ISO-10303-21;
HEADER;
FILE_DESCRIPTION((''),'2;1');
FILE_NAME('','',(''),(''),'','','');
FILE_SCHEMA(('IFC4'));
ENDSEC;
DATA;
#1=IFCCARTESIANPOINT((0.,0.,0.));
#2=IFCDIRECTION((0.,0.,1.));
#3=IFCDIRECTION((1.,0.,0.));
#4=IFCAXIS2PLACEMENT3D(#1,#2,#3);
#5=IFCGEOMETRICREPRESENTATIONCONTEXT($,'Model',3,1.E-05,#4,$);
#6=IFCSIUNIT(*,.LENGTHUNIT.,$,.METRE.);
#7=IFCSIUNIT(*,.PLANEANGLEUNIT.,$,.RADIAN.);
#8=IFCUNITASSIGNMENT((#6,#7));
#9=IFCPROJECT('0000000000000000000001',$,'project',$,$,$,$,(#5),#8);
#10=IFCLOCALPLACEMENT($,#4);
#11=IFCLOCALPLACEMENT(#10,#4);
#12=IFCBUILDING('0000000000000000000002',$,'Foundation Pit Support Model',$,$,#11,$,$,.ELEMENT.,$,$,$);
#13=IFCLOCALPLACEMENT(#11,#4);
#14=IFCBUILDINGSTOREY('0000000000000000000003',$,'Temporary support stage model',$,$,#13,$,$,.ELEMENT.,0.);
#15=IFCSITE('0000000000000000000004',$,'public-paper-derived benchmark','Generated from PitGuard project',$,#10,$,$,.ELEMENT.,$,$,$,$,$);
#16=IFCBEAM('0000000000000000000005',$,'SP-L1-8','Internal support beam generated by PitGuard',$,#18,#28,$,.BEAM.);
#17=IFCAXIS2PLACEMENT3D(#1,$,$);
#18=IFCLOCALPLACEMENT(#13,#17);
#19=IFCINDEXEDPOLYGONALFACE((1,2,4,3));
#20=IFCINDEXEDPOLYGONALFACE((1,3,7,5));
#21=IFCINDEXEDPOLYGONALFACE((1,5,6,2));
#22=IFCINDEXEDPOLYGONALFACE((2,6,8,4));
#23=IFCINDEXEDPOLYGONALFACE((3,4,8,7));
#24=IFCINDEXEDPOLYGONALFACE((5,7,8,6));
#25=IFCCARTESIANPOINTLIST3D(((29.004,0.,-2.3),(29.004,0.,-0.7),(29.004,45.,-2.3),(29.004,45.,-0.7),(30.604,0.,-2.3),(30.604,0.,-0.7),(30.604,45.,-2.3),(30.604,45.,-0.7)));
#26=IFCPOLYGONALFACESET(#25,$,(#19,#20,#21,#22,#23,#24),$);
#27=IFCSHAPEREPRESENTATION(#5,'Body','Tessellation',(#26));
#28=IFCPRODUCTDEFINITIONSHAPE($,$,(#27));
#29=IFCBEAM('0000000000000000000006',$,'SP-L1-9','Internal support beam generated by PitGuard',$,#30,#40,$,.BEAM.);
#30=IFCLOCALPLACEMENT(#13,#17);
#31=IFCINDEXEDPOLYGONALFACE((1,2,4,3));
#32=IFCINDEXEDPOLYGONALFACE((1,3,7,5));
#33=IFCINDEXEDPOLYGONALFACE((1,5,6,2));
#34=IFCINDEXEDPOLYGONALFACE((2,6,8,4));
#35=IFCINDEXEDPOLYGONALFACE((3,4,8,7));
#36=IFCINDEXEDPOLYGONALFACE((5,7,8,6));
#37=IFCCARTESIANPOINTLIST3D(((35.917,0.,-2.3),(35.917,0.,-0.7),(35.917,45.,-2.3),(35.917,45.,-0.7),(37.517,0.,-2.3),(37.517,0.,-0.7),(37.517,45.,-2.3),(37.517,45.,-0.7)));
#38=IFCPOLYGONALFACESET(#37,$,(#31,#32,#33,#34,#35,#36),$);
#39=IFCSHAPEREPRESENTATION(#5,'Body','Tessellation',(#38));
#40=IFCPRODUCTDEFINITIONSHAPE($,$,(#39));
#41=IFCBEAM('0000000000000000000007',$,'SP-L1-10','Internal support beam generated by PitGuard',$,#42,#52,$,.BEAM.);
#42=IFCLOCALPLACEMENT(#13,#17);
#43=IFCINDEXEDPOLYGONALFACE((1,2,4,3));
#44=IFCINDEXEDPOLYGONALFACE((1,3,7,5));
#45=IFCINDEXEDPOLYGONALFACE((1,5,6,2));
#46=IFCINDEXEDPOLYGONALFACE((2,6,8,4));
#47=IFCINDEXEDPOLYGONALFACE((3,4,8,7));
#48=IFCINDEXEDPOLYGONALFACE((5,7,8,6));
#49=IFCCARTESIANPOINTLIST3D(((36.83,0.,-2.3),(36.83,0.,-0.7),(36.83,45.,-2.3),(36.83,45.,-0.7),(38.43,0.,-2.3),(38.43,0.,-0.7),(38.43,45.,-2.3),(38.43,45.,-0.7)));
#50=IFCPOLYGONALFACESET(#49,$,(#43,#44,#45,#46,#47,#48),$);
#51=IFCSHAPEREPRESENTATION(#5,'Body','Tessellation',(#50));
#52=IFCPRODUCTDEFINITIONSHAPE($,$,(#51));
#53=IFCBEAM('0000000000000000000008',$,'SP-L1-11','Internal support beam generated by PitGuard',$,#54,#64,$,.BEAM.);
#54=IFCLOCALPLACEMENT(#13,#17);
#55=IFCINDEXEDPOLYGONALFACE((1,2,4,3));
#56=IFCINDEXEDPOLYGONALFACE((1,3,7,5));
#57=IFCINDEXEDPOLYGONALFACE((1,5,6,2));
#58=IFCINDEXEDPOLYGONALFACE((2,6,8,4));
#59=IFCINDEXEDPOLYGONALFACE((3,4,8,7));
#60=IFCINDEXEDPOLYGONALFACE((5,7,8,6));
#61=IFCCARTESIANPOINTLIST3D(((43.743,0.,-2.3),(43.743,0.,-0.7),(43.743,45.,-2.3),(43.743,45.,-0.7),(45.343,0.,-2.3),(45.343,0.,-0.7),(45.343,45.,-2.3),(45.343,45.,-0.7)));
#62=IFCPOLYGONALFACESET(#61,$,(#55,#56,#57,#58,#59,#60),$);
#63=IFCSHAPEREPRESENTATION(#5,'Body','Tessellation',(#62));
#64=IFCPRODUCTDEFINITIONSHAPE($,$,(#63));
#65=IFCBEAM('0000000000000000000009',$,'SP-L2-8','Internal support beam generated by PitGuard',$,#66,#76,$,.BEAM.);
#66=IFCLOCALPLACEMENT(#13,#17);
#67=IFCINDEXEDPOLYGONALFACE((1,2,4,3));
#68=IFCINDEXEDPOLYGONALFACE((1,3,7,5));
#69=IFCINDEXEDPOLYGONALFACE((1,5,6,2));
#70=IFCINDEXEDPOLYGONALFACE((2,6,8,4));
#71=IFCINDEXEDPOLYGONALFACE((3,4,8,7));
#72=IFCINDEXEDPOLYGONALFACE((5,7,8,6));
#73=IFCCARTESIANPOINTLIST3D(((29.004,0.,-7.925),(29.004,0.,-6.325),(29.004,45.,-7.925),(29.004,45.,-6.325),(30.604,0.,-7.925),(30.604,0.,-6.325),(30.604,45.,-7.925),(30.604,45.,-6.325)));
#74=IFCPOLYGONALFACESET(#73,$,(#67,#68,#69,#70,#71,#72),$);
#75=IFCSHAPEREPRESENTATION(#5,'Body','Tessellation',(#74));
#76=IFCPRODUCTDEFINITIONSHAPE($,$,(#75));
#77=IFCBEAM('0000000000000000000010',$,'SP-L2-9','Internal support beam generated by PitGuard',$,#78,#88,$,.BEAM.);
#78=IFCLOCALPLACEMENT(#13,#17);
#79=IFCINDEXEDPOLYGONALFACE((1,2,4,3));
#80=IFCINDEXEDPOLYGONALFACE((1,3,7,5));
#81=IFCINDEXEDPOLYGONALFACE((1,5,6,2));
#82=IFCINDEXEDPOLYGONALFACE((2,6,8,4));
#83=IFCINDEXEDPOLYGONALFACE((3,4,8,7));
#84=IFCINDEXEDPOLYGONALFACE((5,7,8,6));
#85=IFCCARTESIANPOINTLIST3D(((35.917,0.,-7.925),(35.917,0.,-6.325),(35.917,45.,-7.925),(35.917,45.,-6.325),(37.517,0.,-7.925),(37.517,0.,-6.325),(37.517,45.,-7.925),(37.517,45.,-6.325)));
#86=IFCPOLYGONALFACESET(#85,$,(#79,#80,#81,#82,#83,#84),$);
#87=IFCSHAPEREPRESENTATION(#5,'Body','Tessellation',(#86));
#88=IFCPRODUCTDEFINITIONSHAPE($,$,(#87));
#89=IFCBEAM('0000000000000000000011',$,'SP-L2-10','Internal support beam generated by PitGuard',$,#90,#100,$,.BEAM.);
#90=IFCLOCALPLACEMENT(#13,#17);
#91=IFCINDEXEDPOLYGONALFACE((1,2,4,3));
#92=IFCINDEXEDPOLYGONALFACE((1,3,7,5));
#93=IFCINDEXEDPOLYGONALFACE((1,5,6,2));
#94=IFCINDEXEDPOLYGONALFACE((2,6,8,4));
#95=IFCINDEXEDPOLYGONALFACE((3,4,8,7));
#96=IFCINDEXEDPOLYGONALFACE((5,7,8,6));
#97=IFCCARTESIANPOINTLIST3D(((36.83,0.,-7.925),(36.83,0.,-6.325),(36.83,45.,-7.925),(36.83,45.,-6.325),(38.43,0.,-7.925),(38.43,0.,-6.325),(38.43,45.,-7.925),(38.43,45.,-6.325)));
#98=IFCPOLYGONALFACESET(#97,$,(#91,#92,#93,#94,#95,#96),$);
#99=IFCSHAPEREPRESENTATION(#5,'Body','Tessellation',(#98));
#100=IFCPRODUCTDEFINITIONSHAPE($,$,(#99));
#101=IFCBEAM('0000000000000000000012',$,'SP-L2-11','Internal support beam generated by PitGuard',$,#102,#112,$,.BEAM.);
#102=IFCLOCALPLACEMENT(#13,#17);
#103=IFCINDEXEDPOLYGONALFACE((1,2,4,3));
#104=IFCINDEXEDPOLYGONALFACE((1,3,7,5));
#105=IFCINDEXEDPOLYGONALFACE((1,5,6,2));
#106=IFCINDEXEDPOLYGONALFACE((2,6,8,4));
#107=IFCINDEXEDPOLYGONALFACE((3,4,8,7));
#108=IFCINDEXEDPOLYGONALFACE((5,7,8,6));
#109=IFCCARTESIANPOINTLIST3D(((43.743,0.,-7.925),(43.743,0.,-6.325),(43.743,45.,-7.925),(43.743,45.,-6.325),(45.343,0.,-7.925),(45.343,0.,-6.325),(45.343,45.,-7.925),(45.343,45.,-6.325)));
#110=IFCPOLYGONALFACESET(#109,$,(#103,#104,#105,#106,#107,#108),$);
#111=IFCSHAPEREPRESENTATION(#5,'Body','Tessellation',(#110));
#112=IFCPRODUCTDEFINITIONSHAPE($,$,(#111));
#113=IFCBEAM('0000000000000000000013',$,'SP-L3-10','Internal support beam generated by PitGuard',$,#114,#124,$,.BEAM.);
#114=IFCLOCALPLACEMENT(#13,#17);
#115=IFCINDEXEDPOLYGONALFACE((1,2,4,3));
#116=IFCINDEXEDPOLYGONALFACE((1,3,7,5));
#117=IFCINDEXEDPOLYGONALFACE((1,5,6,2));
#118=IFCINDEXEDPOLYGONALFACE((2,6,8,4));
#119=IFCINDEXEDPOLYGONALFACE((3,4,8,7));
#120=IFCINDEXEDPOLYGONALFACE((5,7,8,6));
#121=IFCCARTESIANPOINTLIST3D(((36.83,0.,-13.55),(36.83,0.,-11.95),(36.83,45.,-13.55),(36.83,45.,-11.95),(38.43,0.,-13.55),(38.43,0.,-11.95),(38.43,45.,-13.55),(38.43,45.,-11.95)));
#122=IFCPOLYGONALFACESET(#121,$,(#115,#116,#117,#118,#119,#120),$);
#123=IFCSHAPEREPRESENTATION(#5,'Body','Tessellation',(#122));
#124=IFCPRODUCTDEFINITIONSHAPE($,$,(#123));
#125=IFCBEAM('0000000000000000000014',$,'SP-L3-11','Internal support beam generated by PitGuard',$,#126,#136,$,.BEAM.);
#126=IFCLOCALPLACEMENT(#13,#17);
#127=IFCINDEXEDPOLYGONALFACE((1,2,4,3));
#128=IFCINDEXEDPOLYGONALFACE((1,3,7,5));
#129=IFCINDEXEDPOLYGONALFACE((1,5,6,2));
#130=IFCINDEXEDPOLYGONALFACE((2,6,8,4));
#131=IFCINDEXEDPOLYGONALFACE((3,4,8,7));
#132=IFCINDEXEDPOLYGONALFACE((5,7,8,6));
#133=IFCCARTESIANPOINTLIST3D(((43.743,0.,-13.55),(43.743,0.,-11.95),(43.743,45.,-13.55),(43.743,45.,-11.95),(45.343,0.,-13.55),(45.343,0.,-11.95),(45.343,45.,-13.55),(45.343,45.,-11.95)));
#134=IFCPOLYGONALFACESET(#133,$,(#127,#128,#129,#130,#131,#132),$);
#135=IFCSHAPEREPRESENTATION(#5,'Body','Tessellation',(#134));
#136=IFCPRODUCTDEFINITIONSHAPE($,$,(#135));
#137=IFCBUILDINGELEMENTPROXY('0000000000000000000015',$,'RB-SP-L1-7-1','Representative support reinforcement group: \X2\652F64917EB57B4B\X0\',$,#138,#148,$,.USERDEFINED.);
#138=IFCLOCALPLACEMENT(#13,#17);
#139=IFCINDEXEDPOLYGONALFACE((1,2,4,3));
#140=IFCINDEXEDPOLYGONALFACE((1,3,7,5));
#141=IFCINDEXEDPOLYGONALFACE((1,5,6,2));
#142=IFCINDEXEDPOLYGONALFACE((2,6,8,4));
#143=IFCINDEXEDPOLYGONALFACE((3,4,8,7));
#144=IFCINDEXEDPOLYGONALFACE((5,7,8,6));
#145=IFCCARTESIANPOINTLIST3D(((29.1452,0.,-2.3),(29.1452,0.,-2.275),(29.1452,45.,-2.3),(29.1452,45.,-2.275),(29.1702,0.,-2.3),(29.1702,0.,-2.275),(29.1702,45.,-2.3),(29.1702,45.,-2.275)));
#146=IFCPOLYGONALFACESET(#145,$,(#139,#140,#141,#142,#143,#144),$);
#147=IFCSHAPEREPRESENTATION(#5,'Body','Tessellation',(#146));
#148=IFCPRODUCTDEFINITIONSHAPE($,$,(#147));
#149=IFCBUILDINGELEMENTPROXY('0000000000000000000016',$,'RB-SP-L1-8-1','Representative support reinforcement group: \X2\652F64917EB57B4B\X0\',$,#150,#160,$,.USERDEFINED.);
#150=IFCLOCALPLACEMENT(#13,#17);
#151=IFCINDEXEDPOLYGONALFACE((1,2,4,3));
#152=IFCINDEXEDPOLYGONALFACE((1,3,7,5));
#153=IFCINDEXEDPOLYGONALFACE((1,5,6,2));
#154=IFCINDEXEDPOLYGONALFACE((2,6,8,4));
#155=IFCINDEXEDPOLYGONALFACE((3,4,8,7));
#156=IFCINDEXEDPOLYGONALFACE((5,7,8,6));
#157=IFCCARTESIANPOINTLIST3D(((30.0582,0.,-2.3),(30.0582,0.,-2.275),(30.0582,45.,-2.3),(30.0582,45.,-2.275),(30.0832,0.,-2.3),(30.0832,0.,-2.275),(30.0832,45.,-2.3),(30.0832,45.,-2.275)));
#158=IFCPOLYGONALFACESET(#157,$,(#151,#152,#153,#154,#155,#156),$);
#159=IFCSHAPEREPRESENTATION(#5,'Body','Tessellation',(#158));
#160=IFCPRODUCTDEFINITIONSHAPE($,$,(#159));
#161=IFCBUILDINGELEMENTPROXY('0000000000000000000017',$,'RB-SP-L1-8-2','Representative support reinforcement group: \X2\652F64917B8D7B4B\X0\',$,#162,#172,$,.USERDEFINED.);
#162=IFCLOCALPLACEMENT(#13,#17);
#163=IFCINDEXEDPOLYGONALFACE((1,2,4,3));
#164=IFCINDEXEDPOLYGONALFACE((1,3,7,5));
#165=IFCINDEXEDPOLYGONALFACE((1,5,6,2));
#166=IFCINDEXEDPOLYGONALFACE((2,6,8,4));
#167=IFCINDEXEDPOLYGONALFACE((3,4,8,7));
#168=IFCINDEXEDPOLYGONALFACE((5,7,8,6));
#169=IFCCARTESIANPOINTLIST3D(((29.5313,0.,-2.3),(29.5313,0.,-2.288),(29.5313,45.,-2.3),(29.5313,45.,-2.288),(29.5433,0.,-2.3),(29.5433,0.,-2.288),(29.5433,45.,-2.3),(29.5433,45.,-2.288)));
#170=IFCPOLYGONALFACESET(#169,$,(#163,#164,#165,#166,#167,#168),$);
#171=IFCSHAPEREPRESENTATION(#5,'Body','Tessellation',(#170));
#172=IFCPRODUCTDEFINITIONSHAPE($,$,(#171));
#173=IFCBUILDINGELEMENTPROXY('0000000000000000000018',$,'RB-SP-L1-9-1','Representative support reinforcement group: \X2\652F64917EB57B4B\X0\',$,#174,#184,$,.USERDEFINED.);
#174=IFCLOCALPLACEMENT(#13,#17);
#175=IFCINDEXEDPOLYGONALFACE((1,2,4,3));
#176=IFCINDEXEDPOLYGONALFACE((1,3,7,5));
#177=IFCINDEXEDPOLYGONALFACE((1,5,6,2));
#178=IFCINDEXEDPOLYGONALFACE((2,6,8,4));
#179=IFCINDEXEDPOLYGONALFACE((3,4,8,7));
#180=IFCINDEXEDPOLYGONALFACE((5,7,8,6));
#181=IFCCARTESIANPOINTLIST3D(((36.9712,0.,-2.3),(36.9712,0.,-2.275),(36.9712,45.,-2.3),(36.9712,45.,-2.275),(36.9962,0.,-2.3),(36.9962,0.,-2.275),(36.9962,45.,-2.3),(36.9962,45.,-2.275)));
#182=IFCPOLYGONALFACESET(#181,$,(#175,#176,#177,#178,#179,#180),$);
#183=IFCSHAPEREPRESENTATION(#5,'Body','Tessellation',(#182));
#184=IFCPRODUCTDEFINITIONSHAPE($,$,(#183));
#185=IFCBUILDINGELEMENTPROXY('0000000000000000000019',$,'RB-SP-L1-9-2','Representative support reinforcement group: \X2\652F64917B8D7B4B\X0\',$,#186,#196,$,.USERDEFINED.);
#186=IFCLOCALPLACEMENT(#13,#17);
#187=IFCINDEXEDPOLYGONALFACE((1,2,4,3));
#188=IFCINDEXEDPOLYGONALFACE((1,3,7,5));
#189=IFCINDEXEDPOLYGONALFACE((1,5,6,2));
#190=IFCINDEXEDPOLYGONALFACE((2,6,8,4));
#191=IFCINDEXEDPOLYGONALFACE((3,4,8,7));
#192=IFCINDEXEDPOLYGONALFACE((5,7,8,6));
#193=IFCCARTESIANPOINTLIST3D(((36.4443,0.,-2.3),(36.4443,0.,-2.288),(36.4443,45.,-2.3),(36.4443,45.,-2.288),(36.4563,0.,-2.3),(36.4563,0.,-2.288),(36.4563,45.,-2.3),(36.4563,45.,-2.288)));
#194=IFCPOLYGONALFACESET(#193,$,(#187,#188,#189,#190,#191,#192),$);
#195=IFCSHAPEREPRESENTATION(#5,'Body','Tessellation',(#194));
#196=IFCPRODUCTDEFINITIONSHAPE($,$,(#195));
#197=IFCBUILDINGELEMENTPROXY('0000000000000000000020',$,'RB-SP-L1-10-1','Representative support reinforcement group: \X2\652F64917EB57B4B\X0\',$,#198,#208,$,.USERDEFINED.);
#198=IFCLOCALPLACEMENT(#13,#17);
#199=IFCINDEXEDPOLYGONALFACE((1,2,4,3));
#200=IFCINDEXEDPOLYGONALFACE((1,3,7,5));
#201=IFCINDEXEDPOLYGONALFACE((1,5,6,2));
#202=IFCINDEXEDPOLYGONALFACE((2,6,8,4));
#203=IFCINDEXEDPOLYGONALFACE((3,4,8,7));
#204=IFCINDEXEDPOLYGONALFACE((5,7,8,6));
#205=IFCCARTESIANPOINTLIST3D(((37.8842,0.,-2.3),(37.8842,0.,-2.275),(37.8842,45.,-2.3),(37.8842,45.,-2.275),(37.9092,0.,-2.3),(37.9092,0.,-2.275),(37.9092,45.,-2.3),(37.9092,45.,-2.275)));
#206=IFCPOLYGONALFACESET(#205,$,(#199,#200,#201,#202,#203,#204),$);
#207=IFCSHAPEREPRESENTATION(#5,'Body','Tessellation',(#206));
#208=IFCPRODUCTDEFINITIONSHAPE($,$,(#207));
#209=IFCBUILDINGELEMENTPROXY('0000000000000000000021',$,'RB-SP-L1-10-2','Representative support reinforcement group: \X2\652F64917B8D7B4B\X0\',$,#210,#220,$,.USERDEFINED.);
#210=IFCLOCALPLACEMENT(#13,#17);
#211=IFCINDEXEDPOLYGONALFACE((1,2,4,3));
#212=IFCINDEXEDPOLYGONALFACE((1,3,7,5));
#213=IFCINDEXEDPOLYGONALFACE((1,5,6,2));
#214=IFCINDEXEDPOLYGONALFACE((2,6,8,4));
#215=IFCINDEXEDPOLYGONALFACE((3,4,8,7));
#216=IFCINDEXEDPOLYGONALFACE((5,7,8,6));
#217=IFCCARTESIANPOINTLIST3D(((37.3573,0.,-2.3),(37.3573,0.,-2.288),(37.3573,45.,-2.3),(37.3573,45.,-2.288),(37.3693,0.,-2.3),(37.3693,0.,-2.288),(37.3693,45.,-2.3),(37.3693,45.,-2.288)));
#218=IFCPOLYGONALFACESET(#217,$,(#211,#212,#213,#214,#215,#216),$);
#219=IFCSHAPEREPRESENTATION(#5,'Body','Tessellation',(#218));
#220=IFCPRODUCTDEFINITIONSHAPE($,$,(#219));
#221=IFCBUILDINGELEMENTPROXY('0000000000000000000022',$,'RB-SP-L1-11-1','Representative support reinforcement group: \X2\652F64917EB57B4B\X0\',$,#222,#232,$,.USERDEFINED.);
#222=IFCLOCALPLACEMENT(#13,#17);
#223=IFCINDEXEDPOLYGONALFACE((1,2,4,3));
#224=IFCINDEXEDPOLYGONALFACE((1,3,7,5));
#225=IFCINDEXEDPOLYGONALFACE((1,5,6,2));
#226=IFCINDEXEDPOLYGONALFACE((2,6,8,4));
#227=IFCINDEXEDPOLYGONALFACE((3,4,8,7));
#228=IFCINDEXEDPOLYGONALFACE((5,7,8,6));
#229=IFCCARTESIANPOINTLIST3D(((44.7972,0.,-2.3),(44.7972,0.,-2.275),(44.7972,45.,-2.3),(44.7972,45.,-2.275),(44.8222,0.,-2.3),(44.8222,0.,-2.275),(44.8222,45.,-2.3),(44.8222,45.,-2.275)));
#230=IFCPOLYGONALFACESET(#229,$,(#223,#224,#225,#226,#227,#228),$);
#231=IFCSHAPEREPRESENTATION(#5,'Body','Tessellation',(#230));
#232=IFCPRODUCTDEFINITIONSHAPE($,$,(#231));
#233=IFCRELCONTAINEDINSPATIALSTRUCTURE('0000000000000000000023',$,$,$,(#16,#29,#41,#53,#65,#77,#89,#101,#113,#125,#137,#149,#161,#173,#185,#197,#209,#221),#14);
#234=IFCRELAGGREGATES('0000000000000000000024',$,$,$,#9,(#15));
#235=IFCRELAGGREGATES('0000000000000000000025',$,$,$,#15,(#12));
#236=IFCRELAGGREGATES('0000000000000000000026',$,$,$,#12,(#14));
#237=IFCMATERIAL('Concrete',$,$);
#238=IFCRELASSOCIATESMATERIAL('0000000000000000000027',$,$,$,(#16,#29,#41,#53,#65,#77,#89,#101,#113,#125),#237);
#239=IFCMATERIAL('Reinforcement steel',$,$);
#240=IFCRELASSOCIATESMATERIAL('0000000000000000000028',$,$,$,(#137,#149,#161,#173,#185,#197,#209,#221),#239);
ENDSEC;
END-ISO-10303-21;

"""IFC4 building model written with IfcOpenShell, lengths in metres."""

from ifc_helpers import new_model, si_unit, frame, origin_with_axes, origin_2d, place, context, project, spatial, rectangle, extrude, material, element, save


model = new_model("IFC4")

# Units and contexts
model_context = context("Model", 3, precision=1e-05, world=origin_with_axes())
ifc_project = project(units=[si_unit("LENGTHUNIT", "METRE"), si_unit("PLANEANGLEUNIT", "RADIAN")], contexts=[model_context])

# Site, building, storey
site_placement = place(None, origin_with_axes())
site = spatial("IfcSite", under=ifc_project, at=site_placement, Name="public-paper-derived benchmark", Description="Generated from PitGuard project", CompositionType="ELEMENT")
building_placement = place(site_placement, origin_with_axes())
building = spatial("IfcBuilding", under=site, at=building_placement, Name="Foundation Pit Support Model", CompositionType="ELEMENT")
storey_placement = place(building_placement, origin_with_axes())
storey = spatial("IfcBuildingStorey", under=building, at=storey_placement, Name="Temporary support stage model", CompositionType="ELEMENT", Elevation=0.0)

# Beams
ifc_material_1 = material(Name="Concrete")
for number, where, z_axis, x_axis, name in (
    (1, (29.804, 22.5, -2.3), (0.0, 0.0, 1.0), (0.0, 1.0, 0.0), "SP-L1-8"),
    (2, (36.717, 22.5, -2.3), (0.0, 0.0, 1.0), (0.0, 1.0, 0.0), "SP-L1-9"),
    (3, (37.63, 22.5, -2.3), (0.0, 0.0, 1.0), (0.0, 1.0, 0.0), "SP-L1-10"),
    (4, (44.543, 22.5, -2.3), (0.0, 0.0, 1.0), (0.0, 1.0, 0.0), "SP-L1-11"),
    (5, (29.804, 22.5, -7.925), (0.0, 0.0, 1.0), (0.0, 1.0, 0.0), "SP-L2-8"),
    (6, (36.717, 22.5, -7.925), (0.0, 0.0, 1.0), (0.0, 1.0, 0.0), "SP-L2-9"),
    (7, (37.63, 22.5, -7.925), (0.0, 0.0, 1.0), (0.0, 1.0, 0.0), "SP-L2-10"),
    (8, (44.543, 22.5, -7.925), (0.0, 0.0, 1.0), (0.0, 1.0, 0.0), "SP-L2-11"),
    (9, (37.63, 22.5, -13.55), (0.0, 0.0, 1.0), (0.0, 1.0, 0.0), "SP-L3-10"),
    (10, (44.543, 22.5, -13.55), (0.0, 0.0, 1.0), (0.0, 1.0, 0.0), "SP-L3-11"),
):
    element("IfcBeam", number, at=place(storey_placement, frame(where, z_axis=z_axis, x_axis=x_axis)), inside=storey, material=ifc_material_1, Name=name, Description="Internal support beam generated by PitGuard", PredefinedType="BEAM", context=model_context, shape_type="SweptSolid", body=[
        extrude(rectangle(XDim=45.0, YDim=1.6, at=origin_2d()), origin_with_axes(), (0.0, 0.0, 1.0), 1.6),
    ])

# Building element proxies
ifc_material_2 = material(Name="Reinforcement steel")
for number, where, z_axis, x_axis, name in (
    (11, (29.1577, 22.5, -2.3), (0.0, 0.0, 1.0), (0.0, 1.0, 0.0), "RB-SP-L1-7-1"),
    (12, (30.0707, 22.5, -2.3), (0.0, 0.0, 1.0), (0.0, 1.0, 0.0), "RB-SP-L1-8-1"),
):
    element("IfcBuildingElementProxy", number, at=place(storey_placement, frame(where, z_axis=z_axis, x_axis=x_axis)), inside=storey, material=ifc_material_2, Name=name, Description="Representative support reinforcement group: 支撑纵筋", PredefinedType="USERDEFINED", context=model_context, shape_type="SweptSolid", body=[
        extrude(rectangle(XDim=45.0, YDim=0.025, at=origin_2d()), origin_with_axes(), (0.0, 0.0, 1.0), 0.025),
    ])
proxy_1_placement = place(storey_placement, frame((29.5373, 22.5, -2.3), z_axis=(0.0, 0.0, 1.0), x_axis=(0.0, 1.0, 0.0)))
element("IfcBuildingElementProxy", 13, at=proxy_1_placement, inside=storey, material=ifc_material_2, Name="RB-SP-L1-8-2", Description="Representative support reinforcement group: 支撑箍筋", PredefinedType="USERDEFINED", context=model_context, shape_type="SweptSolid", body=[
    extrude(rectangle(XDim=45.0, YDim=0.012, at=origin_2d()), origin_with_axes(), (0.0, 0.0, 1.0), 0.012),
])
proxy_2_placement = place(storey_placement, frame((36.9837, 22.5, -2.3), z_axis=(0.0, 0.0, 1.0), x_axis=(0.0, 1.0, 0.0)))
element("IfcBuildingElementProxy", 14, at=proxy_2_placement, inside=storey, material=ifc_material_2, Name="RB-SP-L1-9-1", Description="Representative support reinforcement group: 支撑纵筋", PredefinedType="USERDEFINED", context=model_context, shape_type="SweptSolid", body=[
    extrude(rectangle(XDim=45.0, YDim=0.025, at=origin_2d()), origin_with_axes(), (0.0, 0.0, 1.0), 0.025),
])
proxy_3_placement = place(storey_placement, frame((36.4503, 22.5, -2.3), z_axis=(0.0, 0.0, 1.0), x_axis=(0.0, 1.0, 0.0)))
element("IfcBuildingElementProxy", 15, at=proxy_3_placement, inside=storey, material=ifc_material_2, Name="RB-SP-L1-9-2", Description="Representative support reinforcement group: 支撑箍筋", PredefinedType="USERDEFINED", context=model_context, shape_type="SweptSolid", body=[
    extrude(rectangle(XDim=45.0, YDim=0.012, at=origin_2d()), origin_with_axes(), (0.0, 0.0, 1.0), 0.012),
])
proxy_4_placement = place(storey_placement, frame((37.8967, 22.5, -2.3), z_axis=(0.0, 0.0, 1.0), x_axis=(0.0, 1.0, 0.0)))
element("IfcBuildingElementProxy", 16, at=proxy_4_placement, inside=storey, material=ifc_material_2, Name="RB-SP-L1-10-1", Description="Representative support reinforcement group: 支撑纵筋", PredefinedType="USERDEFINED", context=model_context, shape_type="SweptSolid", body=[
    extrude(rectangle(XDim=45.0, YDim=0.025, at=origin_2d()), origin_with_axes(), (0.0, 0.0, 1.0), 0.025),
])
proxy_5_placement = place(storey_placement, frame((37.3633, 22.5, -2.3), z_axis=(0.0, 0.0, 1.0), x_axis=(0.0, 1.0, 0.0)))
element("IfcBuildingElementProxy", 17, at=proxy_5_placement, inside=storey, material=ifc_material_2, Name="RB-SP-L1-10-2", Description="Representative support reinforcement group: 支撑箍筋", PredefinedType="USERDEFINED", context=model_context, shape_type="SweptSolid", body=[
    extrude(rectangle(XDim=45.0, YDim=0.012, at=origin_2d()), origin_with_axes(), (0.0, 0.0, 1.0), 0.012),
])
proxy_6_placement = place(storey_placement, frame((44.8097, 22.5, -2.3), z_axis=(0.0, 0.0, 1.0), x_axis=(0.0, 1.0, 0.0)))
element("IfcBuildingElementProxy", 18, at=proxy_6_placement, inside=storey, material=ifc_material_2, Name="RB-SP-L1-11-1", Description="Representative support reinforcement group: 支撑纵筋", PredefinedType="USERDEFINED", context=model_context, shape_type="SweptSolid", body=[
    extrude(rectangle(XDim=45.0, YDim=0.025, at=origin_2d()), origin_with_axes(), (0.0, 0.0, 1.0), 0.025),
])

save(model, "model.ifc")
